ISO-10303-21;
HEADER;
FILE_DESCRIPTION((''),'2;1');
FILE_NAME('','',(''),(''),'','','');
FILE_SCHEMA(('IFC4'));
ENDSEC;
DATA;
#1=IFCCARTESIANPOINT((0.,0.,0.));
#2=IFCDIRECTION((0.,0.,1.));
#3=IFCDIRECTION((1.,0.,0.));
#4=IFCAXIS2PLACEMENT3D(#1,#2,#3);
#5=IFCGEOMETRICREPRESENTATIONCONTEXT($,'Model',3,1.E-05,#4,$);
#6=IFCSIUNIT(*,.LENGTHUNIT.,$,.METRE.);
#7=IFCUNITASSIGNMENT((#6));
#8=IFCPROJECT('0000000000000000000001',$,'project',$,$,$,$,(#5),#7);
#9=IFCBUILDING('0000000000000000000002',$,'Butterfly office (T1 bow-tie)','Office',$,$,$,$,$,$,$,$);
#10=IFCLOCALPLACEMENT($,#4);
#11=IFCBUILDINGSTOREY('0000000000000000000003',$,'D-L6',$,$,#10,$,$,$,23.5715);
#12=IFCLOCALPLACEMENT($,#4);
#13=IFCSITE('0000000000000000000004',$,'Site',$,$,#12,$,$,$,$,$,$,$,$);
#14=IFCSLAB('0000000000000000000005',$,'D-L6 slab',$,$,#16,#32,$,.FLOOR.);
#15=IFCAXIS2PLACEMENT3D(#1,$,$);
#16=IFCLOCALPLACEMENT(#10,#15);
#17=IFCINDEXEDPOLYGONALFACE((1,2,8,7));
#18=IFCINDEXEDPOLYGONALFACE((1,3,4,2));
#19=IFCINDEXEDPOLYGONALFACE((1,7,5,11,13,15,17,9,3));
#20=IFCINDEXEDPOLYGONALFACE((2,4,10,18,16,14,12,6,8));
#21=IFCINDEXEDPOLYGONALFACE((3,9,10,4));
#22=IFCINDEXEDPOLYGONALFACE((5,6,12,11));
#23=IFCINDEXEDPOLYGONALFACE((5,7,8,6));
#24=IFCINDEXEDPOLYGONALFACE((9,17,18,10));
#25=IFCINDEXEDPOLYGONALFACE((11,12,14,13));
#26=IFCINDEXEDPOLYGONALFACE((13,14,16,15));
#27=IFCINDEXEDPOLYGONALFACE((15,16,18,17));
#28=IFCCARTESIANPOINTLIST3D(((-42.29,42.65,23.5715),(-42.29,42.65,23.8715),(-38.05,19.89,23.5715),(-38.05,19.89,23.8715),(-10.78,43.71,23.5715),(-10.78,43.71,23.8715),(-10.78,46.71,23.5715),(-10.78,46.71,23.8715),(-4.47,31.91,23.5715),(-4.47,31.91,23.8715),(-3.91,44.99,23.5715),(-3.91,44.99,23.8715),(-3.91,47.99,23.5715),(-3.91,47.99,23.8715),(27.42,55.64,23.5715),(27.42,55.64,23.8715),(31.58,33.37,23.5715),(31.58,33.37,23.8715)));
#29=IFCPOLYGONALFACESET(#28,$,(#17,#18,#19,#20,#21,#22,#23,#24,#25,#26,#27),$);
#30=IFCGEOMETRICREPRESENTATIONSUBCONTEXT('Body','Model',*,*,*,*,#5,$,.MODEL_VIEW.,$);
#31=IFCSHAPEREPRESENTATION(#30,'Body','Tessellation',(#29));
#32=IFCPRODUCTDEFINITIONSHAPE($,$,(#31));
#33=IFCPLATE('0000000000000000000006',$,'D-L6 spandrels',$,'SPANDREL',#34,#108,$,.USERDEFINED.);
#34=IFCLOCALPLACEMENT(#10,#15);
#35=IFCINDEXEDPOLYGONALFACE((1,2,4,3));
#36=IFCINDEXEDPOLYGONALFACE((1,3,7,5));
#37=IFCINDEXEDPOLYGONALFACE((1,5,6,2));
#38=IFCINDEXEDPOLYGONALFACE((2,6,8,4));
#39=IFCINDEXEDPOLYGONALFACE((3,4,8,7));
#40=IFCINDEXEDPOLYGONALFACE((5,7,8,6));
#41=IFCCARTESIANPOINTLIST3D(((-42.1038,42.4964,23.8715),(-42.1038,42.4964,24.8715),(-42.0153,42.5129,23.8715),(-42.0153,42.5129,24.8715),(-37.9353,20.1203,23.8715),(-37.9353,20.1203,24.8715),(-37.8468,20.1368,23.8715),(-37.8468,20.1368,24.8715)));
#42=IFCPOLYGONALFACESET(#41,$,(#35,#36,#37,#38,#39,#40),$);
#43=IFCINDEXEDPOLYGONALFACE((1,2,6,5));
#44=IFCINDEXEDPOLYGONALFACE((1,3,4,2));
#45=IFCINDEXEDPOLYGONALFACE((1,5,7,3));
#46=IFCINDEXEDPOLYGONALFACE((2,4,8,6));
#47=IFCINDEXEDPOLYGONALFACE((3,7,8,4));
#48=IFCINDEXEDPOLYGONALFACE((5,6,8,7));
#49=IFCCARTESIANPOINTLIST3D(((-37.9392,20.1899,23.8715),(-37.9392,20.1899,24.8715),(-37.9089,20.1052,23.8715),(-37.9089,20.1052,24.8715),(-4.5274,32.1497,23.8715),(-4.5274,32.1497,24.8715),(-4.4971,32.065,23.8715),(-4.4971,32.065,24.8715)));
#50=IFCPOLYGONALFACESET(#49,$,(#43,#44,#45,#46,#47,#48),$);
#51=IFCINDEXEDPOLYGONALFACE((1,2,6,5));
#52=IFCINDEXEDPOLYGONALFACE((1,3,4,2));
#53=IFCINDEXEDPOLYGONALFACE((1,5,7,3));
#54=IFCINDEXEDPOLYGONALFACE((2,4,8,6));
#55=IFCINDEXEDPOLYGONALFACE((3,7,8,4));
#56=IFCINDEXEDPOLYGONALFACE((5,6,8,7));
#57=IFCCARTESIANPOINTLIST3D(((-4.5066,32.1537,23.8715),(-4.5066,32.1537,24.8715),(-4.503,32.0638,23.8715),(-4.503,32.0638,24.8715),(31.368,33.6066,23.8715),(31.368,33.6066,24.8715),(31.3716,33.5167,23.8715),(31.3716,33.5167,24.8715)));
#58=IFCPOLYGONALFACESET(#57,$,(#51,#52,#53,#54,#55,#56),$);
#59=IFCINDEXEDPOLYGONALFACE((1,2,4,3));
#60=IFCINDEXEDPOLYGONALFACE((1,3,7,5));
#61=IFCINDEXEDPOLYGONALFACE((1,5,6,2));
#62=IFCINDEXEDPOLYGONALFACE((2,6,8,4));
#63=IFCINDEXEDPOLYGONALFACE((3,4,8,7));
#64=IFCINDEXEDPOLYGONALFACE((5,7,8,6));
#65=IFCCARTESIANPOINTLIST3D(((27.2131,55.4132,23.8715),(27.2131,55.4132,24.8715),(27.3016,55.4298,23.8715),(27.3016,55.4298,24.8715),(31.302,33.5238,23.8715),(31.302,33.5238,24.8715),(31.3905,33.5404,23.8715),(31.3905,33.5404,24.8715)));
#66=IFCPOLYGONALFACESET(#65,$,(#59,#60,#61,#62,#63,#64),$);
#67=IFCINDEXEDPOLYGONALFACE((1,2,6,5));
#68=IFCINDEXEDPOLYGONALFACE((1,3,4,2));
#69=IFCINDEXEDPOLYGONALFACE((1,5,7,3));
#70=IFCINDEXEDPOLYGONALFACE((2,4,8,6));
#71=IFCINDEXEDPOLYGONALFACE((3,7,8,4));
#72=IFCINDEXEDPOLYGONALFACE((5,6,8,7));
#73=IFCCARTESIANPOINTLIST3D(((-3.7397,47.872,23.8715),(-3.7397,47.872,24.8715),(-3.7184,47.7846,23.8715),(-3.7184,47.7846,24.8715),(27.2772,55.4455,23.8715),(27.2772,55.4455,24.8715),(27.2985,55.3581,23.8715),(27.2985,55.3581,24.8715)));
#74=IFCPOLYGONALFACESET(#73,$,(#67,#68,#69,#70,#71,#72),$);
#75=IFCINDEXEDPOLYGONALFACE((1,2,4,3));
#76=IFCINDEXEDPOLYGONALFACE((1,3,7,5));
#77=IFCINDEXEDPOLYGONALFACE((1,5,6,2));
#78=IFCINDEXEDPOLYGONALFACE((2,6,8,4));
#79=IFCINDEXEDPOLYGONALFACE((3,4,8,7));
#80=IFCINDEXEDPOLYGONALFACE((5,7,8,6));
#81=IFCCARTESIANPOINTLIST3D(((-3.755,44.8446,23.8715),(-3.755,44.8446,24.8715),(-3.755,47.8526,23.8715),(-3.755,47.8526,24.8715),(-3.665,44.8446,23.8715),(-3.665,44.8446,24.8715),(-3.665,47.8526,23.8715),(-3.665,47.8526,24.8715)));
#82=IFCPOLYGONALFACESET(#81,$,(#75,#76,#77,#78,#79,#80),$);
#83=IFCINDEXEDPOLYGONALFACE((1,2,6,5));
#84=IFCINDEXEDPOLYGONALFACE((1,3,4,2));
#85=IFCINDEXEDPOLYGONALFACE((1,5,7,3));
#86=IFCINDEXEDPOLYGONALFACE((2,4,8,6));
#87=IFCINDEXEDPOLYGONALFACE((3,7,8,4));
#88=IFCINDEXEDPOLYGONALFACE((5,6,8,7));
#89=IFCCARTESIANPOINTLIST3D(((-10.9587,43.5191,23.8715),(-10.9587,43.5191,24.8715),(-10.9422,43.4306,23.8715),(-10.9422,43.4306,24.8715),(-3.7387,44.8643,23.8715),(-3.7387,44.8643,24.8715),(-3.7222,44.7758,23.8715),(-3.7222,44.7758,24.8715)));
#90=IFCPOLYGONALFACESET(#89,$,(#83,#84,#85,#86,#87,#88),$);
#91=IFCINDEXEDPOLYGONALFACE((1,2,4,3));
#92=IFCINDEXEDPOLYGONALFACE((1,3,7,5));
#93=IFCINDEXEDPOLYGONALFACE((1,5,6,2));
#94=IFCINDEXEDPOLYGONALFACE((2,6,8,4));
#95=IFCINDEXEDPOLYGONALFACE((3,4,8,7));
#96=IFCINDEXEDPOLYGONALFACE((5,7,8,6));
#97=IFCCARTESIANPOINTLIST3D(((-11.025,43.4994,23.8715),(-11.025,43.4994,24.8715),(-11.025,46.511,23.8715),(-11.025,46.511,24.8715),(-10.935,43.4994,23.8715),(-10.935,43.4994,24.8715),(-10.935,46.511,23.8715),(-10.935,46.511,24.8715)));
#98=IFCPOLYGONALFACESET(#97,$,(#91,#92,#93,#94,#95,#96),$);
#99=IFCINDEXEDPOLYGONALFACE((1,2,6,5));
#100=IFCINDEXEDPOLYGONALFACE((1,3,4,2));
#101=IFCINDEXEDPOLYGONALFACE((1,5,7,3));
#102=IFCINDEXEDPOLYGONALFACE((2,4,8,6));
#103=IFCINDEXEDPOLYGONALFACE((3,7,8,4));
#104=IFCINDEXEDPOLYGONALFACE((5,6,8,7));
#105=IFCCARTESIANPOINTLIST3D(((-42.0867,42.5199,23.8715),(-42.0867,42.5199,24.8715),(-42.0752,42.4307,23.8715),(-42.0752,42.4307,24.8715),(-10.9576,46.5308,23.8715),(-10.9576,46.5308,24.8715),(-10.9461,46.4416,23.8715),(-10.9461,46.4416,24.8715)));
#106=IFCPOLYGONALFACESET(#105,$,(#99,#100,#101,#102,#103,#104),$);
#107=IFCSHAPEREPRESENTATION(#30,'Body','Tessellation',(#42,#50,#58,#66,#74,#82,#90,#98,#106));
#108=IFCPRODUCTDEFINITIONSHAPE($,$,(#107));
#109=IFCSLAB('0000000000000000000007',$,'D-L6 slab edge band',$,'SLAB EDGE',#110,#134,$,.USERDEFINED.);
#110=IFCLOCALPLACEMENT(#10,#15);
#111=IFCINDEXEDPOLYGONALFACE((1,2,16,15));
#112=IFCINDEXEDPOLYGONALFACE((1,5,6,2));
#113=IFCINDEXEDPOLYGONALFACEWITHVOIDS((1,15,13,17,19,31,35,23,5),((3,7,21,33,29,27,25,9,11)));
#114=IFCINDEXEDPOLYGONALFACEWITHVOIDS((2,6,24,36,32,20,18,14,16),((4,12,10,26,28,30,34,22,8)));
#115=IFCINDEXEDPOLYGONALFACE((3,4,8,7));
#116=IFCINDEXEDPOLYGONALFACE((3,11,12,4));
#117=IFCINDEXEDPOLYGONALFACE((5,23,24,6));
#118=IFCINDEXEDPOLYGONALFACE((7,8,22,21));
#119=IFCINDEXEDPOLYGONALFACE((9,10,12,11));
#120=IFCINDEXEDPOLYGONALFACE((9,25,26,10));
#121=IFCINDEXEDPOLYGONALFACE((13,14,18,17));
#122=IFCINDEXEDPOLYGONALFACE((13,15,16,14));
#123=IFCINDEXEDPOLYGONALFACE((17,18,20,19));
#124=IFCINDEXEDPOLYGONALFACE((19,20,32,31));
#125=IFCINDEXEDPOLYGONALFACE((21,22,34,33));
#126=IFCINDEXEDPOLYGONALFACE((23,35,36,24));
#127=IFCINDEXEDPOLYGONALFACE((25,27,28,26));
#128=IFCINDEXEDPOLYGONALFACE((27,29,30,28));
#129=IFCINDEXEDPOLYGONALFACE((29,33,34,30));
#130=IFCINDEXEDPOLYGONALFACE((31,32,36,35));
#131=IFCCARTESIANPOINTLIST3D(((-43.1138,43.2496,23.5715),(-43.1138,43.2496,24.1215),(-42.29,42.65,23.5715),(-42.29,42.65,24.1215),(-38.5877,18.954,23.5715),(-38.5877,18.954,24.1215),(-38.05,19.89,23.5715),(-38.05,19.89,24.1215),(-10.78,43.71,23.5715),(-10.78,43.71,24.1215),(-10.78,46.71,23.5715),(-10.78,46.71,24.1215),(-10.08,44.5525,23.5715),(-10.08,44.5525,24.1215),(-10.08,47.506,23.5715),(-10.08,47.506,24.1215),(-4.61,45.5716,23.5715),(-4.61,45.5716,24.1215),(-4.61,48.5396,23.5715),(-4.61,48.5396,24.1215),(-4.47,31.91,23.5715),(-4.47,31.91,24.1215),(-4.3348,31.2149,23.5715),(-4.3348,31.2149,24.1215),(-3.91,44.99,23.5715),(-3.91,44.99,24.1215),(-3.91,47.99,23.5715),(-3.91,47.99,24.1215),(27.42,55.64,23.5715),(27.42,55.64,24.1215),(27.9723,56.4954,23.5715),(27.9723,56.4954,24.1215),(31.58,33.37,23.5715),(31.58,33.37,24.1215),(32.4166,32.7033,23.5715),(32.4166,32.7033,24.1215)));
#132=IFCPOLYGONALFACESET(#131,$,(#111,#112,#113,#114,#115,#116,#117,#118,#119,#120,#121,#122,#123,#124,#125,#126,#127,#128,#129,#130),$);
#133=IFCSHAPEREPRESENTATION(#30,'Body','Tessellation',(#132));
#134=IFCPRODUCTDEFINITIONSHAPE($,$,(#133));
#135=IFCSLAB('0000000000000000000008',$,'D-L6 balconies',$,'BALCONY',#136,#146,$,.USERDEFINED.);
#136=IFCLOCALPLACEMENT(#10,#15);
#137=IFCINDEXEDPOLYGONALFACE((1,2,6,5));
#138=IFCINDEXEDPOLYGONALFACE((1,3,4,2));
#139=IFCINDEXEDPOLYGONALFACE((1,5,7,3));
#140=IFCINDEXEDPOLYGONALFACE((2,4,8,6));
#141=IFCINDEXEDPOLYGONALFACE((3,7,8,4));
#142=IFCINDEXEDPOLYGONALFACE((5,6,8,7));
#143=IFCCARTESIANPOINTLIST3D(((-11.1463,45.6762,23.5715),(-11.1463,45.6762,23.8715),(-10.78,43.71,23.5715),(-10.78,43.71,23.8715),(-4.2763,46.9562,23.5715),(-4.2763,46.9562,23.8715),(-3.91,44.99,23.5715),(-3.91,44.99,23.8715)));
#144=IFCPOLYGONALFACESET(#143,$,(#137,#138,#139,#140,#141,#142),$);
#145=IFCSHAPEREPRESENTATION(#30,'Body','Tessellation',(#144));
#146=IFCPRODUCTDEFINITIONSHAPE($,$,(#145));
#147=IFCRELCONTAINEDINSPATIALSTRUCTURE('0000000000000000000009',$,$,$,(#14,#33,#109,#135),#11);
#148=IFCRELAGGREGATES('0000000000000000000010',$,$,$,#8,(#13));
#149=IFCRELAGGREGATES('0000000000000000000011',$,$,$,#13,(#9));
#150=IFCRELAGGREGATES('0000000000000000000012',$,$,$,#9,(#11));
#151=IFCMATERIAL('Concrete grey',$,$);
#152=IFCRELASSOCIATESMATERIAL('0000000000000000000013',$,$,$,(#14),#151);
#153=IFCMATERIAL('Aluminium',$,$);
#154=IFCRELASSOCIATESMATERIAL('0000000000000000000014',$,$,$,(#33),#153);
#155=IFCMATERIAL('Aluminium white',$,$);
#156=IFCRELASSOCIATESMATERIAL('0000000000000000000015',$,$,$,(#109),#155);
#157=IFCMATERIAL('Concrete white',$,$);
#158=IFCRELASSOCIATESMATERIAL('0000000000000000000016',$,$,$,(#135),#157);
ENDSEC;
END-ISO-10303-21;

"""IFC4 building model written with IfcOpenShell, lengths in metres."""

from ifc_helpers import new_model, si_unit, frame, origin_with_axes, place, context, subcontext, project, spatial, polyline, outline, extrude, material, element, save


model = new_model("IFC4")

# Units and contexts
model_context = context("Model", 3, precision=1e-05, world=origin_with_axes())
body_context = subcontext(model_context, "Body", "Model", "MODEL_VIEW")
ifc_project = project(units=[si_unit("LENGTHUNIT", "METRE")], contexts=[model_context])

# Site, building, storey
site_placement = place(None, origin_with_axes())
site = spatial("IfcSite", under=ifc_project, at=site_placement, Name="Site")
building = spatial("IfcBuilding", under=site, Name="Butterfly office (T1 bow-tie)", Description="Office")
storey_placement = place(None, origin_with_axes())
storey = spatial("IfcBuildingStorey", under=building, at=storey_placement, Name="D-L6", Elevation=23.5715)

# Shared definitions
ifc_material_1 = material(Name="Aluminium")

# Slab
ifc_material_2 = material(Name="Concrete grey")
slab_1_placement = place(storey_placement, origin_with_axes())
element("IfcSlab", 1, at=slab_1_placement, inside=storey, material=ifc_material_2, Name="D-L6 slab", PredefinedType="FLOOR", context=body_context, shape_type="SweptSolid", body=[
    extrude(outline(polyline([(-42.29, 42.65), (-38.05, 19.89), (-4.47, 31.91), (31.58, 33.37), (27.42, 55.64), (-3.91, 47.99), (-3.91, 44.99), (-10.78, 43.71), (-10.78, 46.71), (-42.29, 42.65)])), frame((0.0, 0.0, 23.5715), z_axis=(0.0, 0.0, 1.0), x_axis=(1.0, 0.0, 0.0)), (0.0, 0.0, 1.0), 0.3),
])

# Plate
plate_placement = place(storey_placement, origin_with_axes())
element("IfcPlate", 2, at=plate_placement, inside=storey, material=ifc_material_1, Name="D-L6 spandrels", ObjectType="SPANDREL", PredefinedType="USERDEFINED", context=body_context, shape_type="SweptSolid", body=[
    extrude(outline(polyline([(-42.1038, 42.4964), (-37.9353, 20.1203), (-37.8468, 20.1368), (-42.0153, 42.5129), (-42.1038, 42.4964)])), frame((0.0, 0.0, 23.8715), z_axis=(0.0, 0.0, 1.0), x_axis=(1.0, 0.0, 0.0)), (0.0, 0.0, 1.0), 1.0),
    extrude(outline(polyline([(-37.9089, 20.1052), (-4.4971, 32.065), (-4.5274, 32.1497), (-37.9392, 20.1899), (-37.9089, 20.1052)])), frame((0.0, 0.0, 23.8715), z_axis=(0.0, 0.0, 1.0), x_axis=(1.0, 0.0, 0.0)), (0.0, 0.0, 1.0), 1.0),
    extrude(outline(polyline([(-4.503, 32.0638), (31.3716, 33.5167), (31.368, 33.6066), (-4.5066, 32.1537), (-4.503, 32.0638)])), frame((0.0, 0.0, 23.8715), z_axis=(0.0, 0.0, 1.0), x_axis=(1.0, 0.0, 0.0)), (0.0, 0.0, 1.0), 1.0),
    extrude(outline(polyline([(31.3905, 33.5404), (27.3016, 55.4298), (27.2131, 55.4132), (31.302, 33.5238), (31.3905, 33.5404)])), frame((0.0, 0.0, 23.8715), z_axis=(0.0, 0.0, 1.0), x_axis=(1.0, 0.0, 0.0)), (0.0, 0.0, 1.0), 1.0),
    extrude(outline(polyline([(27.2772, 55.4455), (-3.7397, 47.872), (-3.7184, 47.7846), (27.2985, 55.3581), (27.2772, 55.4455)])), frame((0.0, 0.0, 23.8715), z_axis=(0.0, 0.0, 1.0), x_axis=(1.0, 0.0, 0.0)), (0.0, 0.0, 1.0), 1.0),
    extrude(outline(polyline([(-3.755, 47.8526), (-3.755, 44.8446), (-3.665, 44.8446), (-3.665, 47.8526), (-3.755, 47.8526)])), frame((0.0, 0.0, 23.8715), z_axis=(0.0, 0.0, 1.0), x_axis=(1.0, 0.0, 0.0)), (0.0, 0.0, 1.0), 1.0),
    extrude(outline(polyline([(-3.7387, 44.8643), (-10.9587, 43.5191), (-10.9422, 43.4306), (-3.7222, 44.7758), (-3.7387, 44.8643)])), frame((0.0, 0.0, 23.8715), z_axis=(0.0, 0.0, 1.0), x_axis=(1.0, 0.0, 0.0)), (0.0, 0.0, 1.0), 1.0),
    extrude(outline(polyline([(-10.935, 43.4994), (-10.935, 46.511), (-11.025, 46.511), (-11.025, 43.4994), (-10.935, 43.4994)])), frame((0.0, 0.0, 23.8715), z_axis=(0.0, 0.0, 1.0), x_axis=(1.0, 0.0, 0.0)), (0.0, 0.0, 1.0), 1.0),
    extrude(outline(polyline([(-10.9576, 46.5308), (-42.0867, 42.5199), (-42.0752, 42.4307), (-10.9461, 46.4416), (-10.9576, 46.5308)])), frame((0.0, 0.0, 23.8715), z_axis=(0.0, 0.0, 1.0), x_axis=(1.0, 0.0, 0.0)), (0.0, 0.0, 1.0), 1.0),
])

# Slabs
ifc_material_3 = material(Name="Aluminium white")
slab_2_placement = place(storey_placement, origin_with_axes())
element("IfcSlab", 3, at=slab_2_placement, inside=storey, material=ifc_material_3, Name="D-L6 slab edge band", ObjectType="SLAB EDGE", PredefinedType="USERDEFINED", context=body_context, shape_type="SweptSolid", body=[
    extrude(outline(polyline([(-43.1138, 43.2496), (-38.5877, 18.954), (-4.3348, 31.2149), (32.4166, 32.7033), (27.9723, 56.4954), (-4.61, 48.5396), (-4.61, 45.5716), (-10.08, 44.5525), (-10.08, 47.506), (-43.1138, 43.2496)]), holes=[polyline([(-42.29, 42.65), (-38.05, 19.89), (-4.47, 31.91), (31.58, 33.37), (27.42, 55.64), (-3.91, 47.99), (-3.91, 44.99), (-10.78, 43.71), (-10.78, 46.71), (-42.29, 42.65)])]), frame((0.0, 0.0, 23.5715), z_axis=(0.0, 0.0, 1.0), x_axis=(1.0, 0.0, 0.0)), (0.0, 0.0, 1.0), 0.55),
])
ifc_material_4 = material(Name="Concrete white")
slab_3_placement = place(storey_placement, origin_with_axes())
element("IfcSlab", 4, at=slab_3_placement, inside=storey, material=ifc_material_4, Name="D-L6 balconies", ObjectType="BALCONY", PredefinedType="USERDEFINED", context=body_context, shape_type="SweptSolid", body=[
    extrude(outline(polyline([(-3.91, 44.99), (-10.78, 43.71), (-11.1463, 45.6762), (-4.2763, 46.9562), (-3.91, 44.99)])), frame((0.0, 0.0, 23.5715), z_axis=(0.0, 0.0, 1.0), x_axis=(1.0, 0.0, 0.0)), (0.0, 0.0, 1.0), 0.3),
])

save(model, "model.ifc")
